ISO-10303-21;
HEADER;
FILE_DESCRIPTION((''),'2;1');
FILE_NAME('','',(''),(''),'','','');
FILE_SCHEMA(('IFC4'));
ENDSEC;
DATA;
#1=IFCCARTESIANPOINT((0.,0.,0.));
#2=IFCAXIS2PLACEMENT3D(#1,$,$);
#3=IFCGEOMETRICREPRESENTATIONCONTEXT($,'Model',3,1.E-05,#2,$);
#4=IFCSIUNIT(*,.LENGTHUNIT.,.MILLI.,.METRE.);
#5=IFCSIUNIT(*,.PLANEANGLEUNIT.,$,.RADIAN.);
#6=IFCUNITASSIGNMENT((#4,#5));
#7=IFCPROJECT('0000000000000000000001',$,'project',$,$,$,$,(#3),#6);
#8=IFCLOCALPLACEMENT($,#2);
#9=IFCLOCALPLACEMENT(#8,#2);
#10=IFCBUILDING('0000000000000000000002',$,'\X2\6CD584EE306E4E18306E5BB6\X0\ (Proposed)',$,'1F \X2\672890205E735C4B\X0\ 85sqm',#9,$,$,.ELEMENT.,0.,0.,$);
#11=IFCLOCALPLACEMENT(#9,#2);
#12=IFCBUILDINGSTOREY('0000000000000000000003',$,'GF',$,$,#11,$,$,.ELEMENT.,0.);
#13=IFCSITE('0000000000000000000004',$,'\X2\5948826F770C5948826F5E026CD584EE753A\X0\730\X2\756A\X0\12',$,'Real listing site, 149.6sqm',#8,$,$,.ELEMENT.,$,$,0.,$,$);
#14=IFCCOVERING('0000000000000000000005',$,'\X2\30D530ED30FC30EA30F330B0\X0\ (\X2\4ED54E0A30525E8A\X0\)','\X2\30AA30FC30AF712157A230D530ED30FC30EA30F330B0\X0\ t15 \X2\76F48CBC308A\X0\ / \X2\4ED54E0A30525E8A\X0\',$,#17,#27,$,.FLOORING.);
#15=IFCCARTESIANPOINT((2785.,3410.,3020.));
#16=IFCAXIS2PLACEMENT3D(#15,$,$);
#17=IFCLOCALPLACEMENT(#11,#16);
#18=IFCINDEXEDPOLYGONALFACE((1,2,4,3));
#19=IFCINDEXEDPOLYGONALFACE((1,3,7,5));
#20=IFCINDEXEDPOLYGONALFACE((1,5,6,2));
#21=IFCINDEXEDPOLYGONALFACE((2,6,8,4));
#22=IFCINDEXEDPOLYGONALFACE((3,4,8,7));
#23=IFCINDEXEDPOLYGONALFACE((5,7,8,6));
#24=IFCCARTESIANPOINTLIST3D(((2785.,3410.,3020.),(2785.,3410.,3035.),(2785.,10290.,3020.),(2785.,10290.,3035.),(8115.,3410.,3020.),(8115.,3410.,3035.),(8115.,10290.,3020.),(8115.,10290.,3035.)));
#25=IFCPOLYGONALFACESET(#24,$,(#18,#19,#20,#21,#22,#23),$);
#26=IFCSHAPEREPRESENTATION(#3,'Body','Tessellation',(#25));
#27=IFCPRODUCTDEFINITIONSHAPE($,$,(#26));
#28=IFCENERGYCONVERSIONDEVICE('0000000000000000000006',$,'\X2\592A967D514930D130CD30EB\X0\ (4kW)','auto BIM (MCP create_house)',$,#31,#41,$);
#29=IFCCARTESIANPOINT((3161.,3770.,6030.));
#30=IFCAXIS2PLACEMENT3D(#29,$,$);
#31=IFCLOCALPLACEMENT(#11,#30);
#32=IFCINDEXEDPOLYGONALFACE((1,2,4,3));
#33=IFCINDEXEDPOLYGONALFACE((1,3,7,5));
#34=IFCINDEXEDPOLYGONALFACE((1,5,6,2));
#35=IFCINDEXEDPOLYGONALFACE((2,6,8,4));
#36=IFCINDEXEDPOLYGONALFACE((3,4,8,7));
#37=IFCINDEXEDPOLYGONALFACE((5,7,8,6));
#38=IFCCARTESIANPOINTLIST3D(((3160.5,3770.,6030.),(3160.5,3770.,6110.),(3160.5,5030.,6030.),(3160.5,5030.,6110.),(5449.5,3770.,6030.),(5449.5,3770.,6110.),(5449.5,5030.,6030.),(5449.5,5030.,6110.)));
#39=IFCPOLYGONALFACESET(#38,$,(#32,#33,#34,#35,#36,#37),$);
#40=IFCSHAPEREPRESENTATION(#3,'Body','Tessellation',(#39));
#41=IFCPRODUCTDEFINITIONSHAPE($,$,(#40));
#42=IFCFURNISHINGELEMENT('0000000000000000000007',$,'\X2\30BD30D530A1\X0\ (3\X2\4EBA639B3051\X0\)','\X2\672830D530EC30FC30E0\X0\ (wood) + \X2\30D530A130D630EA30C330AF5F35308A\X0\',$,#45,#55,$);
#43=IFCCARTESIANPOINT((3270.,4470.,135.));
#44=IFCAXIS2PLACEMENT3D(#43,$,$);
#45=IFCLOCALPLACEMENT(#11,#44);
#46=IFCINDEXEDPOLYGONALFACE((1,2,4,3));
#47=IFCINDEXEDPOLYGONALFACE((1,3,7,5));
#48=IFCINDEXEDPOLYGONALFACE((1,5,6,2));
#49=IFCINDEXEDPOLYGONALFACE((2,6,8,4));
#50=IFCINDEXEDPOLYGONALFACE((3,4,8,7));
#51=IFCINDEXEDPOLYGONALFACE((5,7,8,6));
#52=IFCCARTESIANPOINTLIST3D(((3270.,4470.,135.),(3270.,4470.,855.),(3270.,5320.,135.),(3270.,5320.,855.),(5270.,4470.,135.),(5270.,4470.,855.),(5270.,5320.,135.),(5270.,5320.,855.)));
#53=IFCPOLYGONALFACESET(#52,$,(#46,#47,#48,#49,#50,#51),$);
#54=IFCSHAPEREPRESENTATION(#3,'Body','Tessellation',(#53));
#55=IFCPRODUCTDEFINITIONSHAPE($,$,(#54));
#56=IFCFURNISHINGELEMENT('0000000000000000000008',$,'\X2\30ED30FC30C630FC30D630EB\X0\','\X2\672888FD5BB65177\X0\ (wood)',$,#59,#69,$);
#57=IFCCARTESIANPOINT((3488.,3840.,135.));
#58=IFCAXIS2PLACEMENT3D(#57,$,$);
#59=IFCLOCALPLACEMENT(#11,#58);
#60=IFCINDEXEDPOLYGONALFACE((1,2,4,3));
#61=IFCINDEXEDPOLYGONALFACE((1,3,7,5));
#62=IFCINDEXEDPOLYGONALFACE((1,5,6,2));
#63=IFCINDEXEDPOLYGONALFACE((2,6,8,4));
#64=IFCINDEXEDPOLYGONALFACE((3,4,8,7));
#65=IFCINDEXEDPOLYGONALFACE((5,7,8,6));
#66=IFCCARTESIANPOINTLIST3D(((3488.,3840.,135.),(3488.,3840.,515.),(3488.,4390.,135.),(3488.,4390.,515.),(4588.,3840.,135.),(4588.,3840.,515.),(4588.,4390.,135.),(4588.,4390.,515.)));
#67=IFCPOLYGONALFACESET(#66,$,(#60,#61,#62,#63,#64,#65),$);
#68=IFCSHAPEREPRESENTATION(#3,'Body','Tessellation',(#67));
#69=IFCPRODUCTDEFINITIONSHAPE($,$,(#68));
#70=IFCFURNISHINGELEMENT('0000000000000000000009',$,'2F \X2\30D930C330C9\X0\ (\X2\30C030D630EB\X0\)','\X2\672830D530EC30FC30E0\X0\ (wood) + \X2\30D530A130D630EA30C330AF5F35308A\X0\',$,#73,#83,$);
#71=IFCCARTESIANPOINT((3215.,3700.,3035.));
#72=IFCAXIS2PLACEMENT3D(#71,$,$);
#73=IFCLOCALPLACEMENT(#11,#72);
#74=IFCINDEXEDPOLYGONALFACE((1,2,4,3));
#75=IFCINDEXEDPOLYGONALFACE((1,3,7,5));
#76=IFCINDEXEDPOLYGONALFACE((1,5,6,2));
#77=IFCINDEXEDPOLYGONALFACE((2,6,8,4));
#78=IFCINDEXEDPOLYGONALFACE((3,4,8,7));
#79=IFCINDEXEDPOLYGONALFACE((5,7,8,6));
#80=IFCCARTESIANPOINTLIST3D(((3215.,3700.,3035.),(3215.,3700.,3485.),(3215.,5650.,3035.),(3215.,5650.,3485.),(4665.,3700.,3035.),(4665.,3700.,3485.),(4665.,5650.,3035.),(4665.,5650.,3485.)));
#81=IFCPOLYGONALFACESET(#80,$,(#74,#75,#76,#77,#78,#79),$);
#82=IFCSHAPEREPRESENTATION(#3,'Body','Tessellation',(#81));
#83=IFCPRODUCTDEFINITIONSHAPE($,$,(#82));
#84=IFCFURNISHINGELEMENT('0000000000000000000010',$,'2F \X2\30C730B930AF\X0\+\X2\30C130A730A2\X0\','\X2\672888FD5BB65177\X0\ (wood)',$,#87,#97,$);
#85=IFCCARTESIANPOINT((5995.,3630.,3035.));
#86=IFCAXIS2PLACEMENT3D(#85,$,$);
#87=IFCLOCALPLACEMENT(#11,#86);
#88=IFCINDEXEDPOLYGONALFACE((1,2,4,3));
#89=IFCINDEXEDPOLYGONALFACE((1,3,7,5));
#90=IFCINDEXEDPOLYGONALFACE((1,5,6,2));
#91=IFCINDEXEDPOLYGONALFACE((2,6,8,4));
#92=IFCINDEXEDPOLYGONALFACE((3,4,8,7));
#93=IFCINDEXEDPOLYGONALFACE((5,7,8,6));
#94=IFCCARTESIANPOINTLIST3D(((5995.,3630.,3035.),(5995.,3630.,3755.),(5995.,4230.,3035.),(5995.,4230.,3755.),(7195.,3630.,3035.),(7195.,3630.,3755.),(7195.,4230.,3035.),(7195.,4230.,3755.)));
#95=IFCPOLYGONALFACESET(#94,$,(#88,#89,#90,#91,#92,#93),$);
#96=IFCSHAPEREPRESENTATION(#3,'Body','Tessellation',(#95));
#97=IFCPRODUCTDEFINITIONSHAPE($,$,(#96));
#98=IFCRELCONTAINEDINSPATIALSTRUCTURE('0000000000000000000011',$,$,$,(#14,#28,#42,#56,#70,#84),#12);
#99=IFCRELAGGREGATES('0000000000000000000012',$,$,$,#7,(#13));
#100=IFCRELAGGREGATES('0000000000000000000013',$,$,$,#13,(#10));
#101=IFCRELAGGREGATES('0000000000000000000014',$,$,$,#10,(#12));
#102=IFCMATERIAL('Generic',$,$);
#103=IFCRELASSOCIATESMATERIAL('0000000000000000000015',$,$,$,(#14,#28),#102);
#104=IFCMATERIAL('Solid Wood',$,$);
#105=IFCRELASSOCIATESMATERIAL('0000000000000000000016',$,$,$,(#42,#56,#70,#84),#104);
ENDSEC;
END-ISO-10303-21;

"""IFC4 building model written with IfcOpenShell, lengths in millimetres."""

from ifc_helpers import new_model, si_unit, frame, frame_2d, origin, place, context, project, spatial, rectangle, extrude, material, element, save


model = new_model("IFC4")

# Units and contexts
model_context = context("Model", 3, precision=1e-05, world=origin())
ifc_project = project(units=[si_unit("LENGTHUNIT", "METRE", prefix="MILLI"), si_unit("PLANEANGLEUNIT", "RADIAN")], contexts=[model_context])

# Site, building, storey
site_placement = place(None, origin())
site = spatial("IfcSite", under=ifc_project, at=site_placement, Name="奈良県奈良市法蓮町730番12", ObjectType="Real listing site, 149.6sqm", CompositionType="ELEMENT", RefElevation=0.0)
building_placement = place(site_placement, origin())
building = spatial("IfcBuilding", under=site, at=building_placement, Name="法蓮の丘の家 (Proposed)", ObjectType="1F 木造平屋 85sqm", CompositionType="ELEMENT", ElevationOfRefHeight=0.0, ElevationOfTerrain=0.0)
storey_placement = place(building_placement, origin())
storey = spatial("IfcBuildingStorey", under=building, at=storey_placement, Name="GF", CompositionType="ELEMENT", Elevation=0.0)

# Shared definitions
ifc_material_1 = material(Name="Solid Wood")

# Shared definitions
ifc_material_2 = material(Name="Generic")

# Covering
covering_placement = place(storey_placement, frame((2785.0, 3410.0, 3020.0)))
element("IfcCovering", 1, at=covering_placement, inside=storey, material=ifc_material_2, Name="フローリング (仕上げ床)", Description="オーク無垢フローリング t15 直貼り / 仕上げ床", PredefinedType="FLOORING", context=model_context, shape_type="SweptSolid", body=[
    extrude(rectangle(XDim=5330.0, YDim=6880.0, at=frame_2d((2665.0, 3440.0))), frame((2785.0, 3410.0, 3020.0)), (0.0, 0.0, 1.0), 15.0),
])

# Energy conversion device
energy_conversion_device_placement = place(storey_placement, frame((3161.0, 3770.0, 6030.0)))
element("IfcEnergyConversionDevice", 2, at=energy_conversion_device_placement, inside=storey, material=ifc_material_2, Name="太陽光パネル (4kW)", Description="auto BIM (MCP create_house)", context=model_context, shape_type="SweptSolid", body=[
    extrude(rectangle(XDim=2289.0, YDim=1260.0, at=frame_2d((1144.0, 630.0))), frame((3161.0, 3770.0, 6030.0)), (0.0, 0.0, 1.0), 80.0),
])

# Furnishing elements
furnishing_1_placement = place(storey_placement, frame((3270.0, 4470.0, 135.0)))
element("IfcFurnishingElement", 3, at=furnishing_1_placement, inside=storey, material=ifc_material_1, Name="ソファ (3人掛け)", Description="木フレーム (wood) + ファブリック張り", context=model_context, shape_type="SweptSolid", body=[
    extrude(rectangle(XDim=2000.0, YDim=850.0, at=frame_2d((1000.0, 425.0))), frame((3270.0, 4470.0, 135.0)), (0.0, 0.0, 1.0), 720.0),
])
furnishing_2_placement = place(storey_placement, frame((3488.0, 3840.0, 135.0)))
element("IfcFurnishingElement", 4, at=furnishing_2_placement, inside=storey, material=ifc_material_1, Name="ローテーブル", Description="木製家具 (wood)", context=model_context, shape_type="SweptSolid", body=[
    extrude(rectangle(XDim=1100.0, YDim=550.0, at=frame_2d((550.0, 275.0))), frame((3488.0, 3840.0, 135.0)), (0.0, 0.0, 1.0), 380.0),
])
furnishing_3_placement = place(storey_placement, frame((3215.0, 3700.0, 3035.0)))
element("IfcFurnishingElement", 5, at=furnishing_3_placement, inside=storey, material=ifc_material_1, Name="2F ベッド (ダブル)", Description="木フレーム (wood) + ファブリック張り", context=model_context, shape_type="SweptSolid", body=[
    extrude(rectangle(XDim=1450.0, YDim=1950.0, at=frame_2d((725.0, 975.0))), frame((3215.0, 3700.0, 3035.0)), (0.0, 0.0, 1.0), 450.0),
])
furnishing_4_placement = place(storey_placement, frame((5995.0, 3630.0, 3035.0)))
element("IfcFurnishingElement", 6, at=furnishing_4_placement, inside=storey, material=ifc_material_1, Name="2F デスク+チェア", Description="木製家具 (wood)", context=model_context, shape_type="SweptSolid", body=[
    extrude(rectangle(XDim=1200.0, YDim=600.0, at=frame_2d((600.0, 300.0))), frame((5995.0, 3630.0, 3035.0)), (0.0, 0.0, 1.0), 720.0),
])

save(model, "model.ifc")
